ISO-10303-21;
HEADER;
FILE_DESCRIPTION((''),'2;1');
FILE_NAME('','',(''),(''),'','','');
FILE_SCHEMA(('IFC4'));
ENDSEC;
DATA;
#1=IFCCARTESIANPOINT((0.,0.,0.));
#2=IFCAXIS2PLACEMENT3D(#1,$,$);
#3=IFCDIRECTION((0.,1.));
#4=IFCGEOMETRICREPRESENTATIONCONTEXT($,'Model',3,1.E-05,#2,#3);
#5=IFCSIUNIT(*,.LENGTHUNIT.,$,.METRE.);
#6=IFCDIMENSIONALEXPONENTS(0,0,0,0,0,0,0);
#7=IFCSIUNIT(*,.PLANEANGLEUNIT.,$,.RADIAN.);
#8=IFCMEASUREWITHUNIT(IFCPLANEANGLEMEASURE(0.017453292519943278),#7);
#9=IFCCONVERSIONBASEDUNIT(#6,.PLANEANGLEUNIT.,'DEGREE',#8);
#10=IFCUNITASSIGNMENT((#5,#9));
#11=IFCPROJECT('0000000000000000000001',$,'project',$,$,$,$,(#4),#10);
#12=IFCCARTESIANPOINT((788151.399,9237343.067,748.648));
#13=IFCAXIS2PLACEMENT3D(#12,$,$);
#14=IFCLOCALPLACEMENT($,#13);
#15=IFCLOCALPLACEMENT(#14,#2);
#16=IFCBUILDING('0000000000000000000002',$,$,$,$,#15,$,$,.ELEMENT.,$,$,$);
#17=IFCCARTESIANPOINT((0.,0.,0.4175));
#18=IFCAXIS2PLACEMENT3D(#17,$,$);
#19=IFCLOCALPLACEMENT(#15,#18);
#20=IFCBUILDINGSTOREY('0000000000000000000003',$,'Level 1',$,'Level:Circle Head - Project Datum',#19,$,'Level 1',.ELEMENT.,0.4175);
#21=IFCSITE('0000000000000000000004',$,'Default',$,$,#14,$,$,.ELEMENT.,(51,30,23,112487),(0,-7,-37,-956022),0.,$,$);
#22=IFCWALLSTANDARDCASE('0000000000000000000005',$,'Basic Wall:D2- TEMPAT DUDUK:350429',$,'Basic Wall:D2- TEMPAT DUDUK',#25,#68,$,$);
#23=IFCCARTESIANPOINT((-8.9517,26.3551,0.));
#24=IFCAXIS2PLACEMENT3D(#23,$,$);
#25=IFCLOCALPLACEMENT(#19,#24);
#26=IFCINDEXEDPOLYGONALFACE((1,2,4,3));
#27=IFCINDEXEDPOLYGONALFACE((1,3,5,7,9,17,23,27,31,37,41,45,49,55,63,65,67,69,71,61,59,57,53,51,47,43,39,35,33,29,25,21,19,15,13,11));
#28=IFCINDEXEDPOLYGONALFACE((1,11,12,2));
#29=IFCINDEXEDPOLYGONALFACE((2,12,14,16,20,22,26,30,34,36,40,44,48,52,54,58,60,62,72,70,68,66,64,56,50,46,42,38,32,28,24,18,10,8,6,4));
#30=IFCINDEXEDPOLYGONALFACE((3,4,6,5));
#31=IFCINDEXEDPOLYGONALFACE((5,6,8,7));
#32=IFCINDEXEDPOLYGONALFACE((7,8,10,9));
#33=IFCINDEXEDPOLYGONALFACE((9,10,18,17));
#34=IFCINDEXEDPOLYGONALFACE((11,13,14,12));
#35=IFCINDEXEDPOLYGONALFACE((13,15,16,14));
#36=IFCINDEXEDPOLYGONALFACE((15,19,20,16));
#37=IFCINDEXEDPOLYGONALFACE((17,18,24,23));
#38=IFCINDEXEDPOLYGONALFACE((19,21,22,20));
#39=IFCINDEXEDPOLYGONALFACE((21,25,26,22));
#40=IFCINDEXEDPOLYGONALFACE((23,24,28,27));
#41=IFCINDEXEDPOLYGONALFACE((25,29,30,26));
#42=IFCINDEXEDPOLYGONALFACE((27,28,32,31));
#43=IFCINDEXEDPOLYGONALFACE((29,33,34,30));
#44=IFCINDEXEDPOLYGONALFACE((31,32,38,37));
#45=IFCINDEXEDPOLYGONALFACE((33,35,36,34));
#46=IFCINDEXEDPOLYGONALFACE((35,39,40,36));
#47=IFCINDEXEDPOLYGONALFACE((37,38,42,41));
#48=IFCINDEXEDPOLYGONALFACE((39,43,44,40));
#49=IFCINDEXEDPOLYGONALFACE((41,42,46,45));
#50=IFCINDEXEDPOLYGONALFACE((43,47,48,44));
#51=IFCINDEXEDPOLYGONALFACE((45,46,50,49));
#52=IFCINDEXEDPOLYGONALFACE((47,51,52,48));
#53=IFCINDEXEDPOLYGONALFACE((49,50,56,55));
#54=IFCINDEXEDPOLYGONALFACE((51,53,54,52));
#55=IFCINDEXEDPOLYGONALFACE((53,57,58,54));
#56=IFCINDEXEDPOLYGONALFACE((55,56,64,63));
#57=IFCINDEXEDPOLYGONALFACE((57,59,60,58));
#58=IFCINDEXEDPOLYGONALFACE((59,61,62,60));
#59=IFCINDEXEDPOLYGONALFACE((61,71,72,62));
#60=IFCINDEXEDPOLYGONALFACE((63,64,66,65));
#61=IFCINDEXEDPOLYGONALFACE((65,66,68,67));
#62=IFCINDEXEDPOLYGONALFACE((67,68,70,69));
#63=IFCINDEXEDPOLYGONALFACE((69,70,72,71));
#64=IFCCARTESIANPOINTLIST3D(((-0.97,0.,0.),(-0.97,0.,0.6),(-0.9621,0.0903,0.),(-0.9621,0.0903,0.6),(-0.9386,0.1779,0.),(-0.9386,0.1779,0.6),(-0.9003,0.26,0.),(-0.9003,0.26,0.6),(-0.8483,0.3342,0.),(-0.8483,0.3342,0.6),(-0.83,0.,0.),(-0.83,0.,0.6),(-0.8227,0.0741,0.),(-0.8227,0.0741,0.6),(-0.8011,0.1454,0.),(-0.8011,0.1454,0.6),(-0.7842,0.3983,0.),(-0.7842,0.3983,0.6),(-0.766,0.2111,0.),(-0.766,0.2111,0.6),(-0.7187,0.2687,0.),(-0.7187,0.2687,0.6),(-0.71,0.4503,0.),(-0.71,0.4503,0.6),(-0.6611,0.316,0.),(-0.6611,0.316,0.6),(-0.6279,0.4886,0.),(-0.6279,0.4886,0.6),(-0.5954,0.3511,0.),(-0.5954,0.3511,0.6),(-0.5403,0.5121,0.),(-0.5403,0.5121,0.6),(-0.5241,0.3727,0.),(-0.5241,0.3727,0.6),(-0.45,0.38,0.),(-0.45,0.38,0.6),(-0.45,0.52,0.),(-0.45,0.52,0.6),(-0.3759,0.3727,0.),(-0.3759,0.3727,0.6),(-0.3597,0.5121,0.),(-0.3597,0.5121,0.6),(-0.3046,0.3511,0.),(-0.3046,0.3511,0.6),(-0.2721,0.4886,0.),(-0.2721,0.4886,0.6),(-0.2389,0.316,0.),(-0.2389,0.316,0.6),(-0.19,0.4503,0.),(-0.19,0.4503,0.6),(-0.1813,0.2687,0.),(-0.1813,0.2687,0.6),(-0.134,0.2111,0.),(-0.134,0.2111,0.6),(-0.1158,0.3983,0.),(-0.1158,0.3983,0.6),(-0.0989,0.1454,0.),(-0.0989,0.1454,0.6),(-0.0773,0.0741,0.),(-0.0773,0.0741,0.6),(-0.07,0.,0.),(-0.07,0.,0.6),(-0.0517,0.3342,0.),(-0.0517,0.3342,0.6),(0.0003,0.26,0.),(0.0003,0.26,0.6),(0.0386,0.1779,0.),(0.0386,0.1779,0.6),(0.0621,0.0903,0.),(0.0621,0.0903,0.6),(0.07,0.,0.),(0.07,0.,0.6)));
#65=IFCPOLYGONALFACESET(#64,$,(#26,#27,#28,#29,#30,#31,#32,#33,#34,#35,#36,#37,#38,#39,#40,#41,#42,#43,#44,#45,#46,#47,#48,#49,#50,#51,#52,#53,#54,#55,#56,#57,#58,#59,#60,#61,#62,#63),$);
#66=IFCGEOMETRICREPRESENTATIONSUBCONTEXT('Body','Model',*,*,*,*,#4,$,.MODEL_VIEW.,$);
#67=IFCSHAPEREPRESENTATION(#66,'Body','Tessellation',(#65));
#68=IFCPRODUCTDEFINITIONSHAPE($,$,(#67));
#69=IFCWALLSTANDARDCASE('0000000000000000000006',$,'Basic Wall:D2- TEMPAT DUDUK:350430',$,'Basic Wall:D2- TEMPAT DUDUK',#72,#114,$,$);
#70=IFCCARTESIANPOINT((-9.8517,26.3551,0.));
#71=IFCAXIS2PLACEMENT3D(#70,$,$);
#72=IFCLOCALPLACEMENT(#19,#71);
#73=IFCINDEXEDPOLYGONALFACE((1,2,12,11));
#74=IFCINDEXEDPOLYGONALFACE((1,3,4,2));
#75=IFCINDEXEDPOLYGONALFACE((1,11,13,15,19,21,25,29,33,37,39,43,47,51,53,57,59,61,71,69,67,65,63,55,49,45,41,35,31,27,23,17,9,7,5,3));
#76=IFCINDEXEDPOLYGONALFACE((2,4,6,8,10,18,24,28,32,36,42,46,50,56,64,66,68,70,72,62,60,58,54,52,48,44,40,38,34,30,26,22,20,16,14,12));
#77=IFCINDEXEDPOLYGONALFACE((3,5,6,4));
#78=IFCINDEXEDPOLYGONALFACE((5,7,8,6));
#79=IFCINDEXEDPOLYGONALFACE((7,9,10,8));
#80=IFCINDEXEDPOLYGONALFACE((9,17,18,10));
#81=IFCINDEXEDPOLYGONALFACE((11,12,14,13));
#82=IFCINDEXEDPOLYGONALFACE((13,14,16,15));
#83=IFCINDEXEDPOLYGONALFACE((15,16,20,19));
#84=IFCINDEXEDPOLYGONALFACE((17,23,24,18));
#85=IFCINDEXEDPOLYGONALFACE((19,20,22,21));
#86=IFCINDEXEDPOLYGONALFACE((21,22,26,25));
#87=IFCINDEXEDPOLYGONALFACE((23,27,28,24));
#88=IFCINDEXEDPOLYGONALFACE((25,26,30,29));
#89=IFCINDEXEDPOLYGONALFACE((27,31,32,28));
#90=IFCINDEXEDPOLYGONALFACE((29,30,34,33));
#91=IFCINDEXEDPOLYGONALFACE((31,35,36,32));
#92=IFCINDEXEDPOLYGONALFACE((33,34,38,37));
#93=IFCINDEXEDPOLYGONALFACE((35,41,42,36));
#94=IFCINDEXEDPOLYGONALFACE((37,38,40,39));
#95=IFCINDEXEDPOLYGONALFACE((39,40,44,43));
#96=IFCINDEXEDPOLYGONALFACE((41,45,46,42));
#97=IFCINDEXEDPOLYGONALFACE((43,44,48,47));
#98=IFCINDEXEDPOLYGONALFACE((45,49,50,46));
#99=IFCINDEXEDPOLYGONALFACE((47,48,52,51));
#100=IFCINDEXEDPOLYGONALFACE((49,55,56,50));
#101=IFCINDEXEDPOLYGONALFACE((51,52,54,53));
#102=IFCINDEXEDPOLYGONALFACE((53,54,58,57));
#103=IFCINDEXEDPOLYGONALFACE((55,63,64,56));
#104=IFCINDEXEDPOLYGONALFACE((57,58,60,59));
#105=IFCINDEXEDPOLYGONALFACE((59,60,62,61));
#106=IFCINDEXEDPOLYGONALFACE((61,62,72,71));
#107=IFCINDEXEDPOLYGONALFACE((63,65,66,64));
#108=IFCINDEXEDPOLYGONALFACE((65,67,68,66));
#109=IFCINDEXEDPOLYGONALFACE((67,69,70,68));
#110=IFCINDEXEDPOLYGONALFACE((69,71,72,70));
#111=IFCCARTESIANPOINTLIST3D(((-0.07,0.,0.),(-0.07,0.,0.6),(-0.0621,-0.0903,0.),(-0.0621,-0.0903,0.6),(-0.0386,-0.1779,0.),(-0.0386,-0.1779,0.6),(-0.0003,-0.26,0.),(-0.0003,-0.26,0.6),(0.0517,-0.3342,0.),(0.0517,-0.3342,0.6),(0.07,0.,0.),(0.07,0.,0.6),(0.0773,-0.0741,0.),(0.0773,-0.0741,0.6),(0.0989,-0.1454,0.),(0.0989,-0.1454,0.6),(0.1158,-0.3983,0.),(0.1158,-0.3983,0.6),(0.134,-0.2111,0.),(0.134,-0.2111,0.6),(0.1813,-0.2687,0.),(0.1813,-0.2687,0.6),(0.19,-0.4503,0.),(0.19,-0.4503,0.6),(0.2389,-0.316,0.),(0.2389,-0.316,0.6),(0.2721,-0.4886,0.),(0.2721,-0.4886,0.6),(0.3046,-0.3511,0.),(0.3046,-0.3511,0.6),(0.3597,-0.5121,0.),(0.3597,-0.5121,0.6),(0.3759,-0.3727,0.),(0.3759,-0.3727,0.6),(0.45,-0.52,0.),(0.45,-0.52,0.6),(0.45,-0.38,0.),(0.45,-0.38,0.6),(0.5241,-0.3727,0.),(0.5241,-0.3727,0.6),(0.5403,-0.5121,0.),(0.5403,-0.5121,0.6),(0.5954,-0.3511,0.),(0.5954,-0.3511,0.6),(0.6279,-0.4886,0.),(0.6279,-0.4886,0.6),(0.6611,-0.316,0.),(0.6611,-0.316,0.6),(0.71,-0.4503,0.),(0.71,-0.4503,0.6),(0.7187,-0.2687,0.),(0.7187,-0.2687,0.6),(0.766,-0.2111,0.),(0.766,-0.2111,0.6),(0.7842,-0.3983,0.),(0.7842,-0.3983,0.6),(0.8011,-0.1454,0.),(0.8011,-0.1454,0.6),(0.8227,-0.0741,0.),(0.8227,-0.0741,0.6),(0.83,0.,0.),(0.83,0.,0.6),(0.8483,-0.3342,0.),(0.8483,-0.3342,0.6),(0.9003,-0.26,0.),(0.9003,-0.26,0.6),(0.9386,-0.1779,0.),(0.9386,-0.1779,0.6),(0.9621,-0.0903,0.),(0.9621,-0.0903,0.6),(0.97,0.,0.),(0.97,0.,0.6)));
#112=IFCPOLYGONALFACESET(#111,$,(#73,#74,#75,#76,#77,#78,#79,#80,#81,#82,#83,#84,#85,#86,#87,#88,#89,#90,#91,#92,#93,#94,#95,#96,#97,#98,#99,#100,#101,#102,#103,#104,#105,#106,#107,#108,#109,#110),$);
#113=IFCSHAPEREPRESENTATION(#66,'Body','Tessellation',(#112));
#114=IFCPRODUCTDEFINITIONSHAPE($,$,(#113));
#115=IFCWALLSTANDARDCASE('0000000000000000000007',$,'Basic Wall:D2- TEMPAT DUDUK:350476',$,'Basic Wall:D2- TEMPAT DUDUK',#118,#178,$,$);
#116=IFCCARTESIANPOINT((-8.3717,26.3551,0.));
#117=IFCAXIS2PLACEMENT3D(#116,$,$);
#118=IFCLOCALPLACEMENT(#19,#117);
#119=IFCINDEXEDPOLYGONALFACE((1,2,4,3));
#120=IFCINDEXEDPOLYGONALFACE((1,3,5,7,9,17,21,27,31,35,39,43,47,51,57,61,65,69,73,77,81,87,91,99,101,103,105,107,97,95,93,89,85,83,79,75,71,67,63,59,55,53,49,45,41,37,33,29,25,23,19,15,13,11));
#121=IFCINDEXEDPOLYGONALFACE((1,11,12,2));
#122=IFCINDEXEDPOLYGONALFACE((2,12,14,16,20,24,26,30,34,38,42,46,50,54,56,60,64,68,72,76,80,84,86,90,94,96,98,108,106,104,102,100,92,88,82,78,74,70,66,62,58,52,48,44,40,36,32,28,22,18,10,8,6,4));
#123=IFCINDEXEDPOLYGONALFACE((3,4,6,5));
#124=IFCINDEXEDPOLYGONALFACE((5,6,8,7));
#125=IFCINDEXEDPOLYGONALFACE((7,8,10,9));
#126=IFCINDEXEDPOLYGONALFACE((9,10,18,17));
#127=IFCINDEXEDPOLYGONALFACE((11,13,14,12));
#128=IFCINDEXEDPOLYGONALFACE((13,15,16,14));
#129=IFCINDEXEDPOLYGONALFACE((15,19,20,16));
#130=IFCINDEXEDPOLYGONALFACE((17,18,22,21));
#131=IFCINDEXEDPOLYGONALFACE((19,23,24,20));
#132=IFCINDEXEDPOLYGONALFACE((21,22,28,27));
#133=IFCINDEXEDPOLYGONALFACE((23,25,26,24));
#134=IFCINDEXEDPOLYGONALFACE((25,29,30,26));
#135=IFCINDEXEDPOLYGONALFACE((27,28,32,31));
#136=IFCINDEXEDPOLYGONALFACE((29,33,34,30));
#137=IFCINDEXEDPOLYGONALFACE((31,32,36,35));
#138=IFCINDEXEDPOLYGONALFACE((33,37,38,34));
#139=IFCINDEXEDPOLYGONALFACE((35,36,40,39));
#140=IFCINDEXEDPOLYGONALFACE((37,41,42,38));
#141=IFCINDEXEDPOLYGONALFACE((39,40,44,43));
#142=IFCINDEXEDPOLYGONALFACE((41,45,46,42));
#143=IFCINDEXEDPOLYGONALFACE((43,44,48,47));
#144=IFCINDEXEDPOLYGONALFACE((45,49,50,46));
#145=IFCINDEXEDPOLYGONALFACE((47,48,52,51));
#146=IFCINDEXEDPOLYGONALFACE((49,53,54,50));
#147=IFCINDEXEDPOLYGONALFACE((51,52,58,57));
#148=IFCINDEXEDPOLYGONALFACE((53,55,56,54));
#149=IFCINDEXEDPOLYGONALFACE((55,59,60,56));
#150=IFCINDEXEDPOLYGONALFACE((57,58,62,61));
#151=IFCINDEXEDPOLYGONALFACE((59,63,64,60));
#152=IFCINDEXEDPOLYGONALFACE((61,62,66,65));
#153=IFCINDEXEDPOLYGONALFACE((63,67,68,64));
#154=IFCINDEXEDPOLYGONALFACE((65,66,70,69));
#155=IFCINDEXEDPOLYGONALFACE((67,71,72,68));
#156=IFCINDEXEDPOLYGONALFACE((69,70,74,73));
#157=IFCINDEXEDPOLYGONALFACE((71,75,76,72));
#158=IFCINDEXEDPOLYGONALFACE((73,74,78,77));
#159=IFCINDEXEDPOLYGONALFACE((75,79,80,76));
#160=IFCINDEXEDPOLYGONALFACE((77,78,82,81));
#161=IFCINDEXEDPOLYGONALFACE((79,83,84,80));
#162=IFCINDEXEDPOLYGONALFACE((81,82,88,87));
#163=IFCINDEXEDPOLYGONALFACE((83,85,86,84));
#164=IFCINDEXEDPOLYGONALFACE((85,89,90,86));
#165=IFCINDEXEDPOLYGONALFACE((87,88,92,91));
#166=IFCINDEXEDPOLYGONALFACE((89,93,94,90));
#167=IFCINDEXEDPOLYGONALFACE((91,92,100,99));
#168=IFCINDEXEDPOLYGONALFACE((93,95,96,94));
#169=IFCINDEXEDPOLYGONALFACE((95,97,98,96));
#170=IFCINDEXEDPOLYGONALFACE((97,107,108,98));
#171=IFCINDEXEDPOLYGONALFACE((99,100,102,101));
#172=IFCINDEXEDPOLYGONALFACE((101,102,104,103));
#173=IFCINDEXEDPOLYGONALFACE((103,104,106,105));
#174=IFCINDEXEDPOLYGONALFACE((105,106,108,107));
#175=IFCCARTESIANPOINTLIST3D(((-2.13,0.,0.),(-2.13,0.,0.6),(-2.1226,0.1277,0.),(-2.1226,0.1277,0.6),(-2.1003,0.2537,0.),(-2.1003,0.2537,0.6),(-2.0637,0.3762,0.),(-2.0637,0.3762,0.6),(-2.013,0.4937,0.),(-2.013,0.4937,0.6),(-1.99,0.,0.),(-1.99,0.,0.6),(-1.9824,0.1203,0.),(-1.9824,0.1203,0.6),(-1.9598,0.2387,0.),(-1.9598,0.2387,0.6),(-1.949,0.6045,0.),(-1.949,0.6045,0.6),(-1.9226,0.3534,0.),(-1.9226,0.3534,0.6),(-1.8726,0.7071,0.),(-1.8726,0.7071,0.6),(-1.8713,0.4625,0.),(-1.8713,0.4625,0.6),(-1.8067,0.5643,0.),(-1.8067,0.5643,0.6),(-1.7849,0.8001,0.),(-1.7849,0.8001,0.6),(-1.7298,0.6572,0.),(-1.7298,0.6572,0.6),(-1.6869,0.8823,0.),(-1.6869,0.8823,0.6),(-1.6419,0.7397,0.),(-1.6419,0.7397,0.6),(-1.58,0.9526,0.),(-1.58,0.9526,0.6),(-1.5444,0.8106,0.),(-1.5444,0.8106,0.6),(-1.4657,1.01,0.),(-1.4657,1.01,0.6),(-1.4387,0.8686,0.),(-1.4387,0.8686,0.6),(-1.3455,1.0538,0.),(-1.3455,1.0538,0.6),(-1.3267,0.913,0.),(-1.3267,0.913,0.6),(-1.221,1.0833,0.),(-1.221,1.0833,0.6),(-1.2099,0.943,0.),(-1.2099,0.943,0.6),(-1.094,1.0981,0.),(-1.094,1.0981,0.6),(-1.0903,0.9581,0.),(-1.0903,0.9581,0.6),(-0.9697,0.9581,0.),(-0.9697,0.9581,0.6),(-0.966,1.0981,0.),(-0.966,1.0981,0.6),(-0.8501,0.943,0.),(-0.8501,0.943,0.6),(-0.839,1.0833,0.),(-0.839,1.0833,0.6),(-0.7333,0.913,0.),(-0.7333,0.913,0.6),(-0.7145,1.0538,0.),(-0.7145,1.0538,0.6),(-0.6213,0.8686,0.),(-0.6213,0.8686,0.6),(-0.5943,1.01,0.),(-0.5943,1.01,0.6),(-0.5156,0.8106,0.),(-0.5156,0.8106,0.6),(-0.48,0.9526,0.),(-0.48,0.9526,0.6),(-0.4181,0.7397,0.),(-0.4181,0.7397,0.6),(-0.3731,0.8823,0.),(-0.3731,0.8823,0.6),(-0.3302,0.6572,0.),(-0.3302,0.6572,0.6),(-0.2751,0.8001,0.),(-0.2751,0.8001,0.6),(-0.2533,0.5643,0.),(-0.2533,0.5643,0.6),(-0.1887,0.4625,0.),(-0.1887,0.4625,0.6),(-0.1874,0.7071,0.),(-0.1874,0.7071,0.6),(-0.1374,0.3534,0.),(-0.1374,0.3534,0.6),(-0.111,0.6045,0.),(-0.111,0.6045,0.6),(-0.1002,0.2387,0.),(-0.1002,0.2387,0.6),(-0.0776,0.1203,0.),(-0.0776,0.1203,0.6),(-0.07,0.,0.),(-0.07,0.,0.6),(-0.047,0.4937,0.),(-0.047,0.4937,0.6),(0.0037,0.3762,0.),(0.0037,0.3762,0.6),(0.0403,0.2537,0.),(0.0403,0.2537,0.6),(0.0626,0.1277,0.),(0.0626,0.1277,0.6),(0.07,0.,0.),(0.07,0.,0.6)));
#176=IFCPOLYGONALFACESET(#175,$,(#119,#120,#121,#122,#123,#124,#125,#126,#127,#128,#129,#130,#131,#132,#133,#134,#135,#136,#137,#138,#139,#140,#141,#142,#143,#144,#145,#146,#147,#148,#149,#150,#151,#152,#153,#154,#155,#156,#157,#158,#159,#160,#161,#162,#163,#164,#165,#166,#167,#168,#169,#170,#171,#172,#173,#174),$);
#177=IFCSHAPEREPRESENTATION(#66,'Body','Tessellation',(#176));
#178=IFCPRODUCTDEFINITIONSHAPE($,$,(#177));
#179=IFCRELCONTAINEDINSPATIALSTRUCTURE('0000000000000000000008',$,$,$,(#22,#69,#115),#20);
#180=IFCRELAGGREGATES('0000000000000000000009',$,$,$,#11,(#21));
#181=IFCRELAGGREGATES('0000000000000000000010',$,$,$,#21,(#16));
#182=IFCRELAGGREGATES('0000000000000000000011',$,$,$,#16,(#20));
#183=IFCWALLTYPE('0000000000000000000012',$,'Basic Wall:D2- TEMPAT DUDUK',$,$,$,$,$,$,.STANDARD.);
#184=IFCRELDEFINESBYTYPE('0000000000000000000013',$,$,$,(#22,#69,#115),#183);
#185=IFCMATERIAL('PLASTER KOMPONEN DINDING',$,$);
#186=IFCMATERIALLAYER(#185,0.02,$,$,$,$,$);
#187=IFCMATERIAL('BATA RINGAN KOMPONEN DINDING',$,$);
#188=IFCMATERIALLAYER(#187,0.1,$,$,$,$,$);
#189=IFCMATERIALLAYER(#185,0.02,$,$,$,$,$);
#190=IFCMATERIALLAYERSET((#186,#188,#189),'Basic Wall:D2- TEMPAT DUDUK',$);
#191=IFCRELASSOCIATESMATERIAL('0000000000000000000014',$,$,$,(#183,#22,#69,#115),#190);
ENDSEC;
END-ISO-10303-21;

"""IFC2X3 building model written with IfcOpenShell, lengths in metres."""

from ifc_helpers import new_model, entity, si_unit, converted_unit, direction, frame, frame_2d, origin, place, context, subcontext, project, spatial, polyline, circle_curve, parameter, trimmed, segment, composite_curve, outline, extrude, material, layer, layer_set, layer_usage, type_object, element, save


model = new_model("IFC2X3")

# Units and contexts
model_context = context("Model", 3, precision=1e-05, world=origin(), true_north=direction((0.0, 1.0)))
body_context = subcontext(model_context, "Body", "Model", "MODEL_VIEW")
ifc_project = project(units=[si_unit("LENGTHUNIT", "METRE"), converted_unit("PLANEANGLEUNIT", "DEGREE", entity("IfcPlaneAngleMeasure", 0.017453292519943278), si_unit("PLANEANGLEUNIT", "RADIAN"), dimensions=[0, 0, 0, 0, 0, 0, 0])], contexts=[model_context])

# Site, building, storey
site_placement = place(None, frame((788151.399, 9237343.067, 748.648)))
site = spatial("IfcSite", under=ifc_project, at=site_placement, Name="Default", CompositionType="ELEMENT", RefLatitude=(51, 30, 23, 112487), RefLongitude=(0, -7, -37, -956022), RefElevation=0.0)
building_placement = place(site_placement, origin())
building = spatial("IfcBuilding", under=site, at=building_placement, CompositionType="ELEMENT")
storey_placement = place(building_placement, frame((0.0, 0.0, 0.4175)))
storey = spatial("IfcBuildingStorey", under=building, at=storey_placement, Name="Level 1", ObjectType="Level:Circle Head - Project Datum", LongName="Level 1", CompositionType="ELEMENT", Elevation=0.4175)

# Walls
ifc_material_1 = material(Name="PLASTER KOMPONEN DINDING")
ifc_material_2 = material(Name="BATA RINGAN KOMPONEN DINDING")
ifc_layer_1 = layer(ifc_material_1, 0.02)
ifc_layer_2 = layer(ifc_material_2, 0.1)
ifc_layer_3 = layer(ifc_material_1, 0.02)
ifc_layer_set_1 = layer_set([ifc_layer_1, ifc_layer_2, ifc_layer_3], Name="Basic Wall:D2- TEMPAT DUDUK")
ifc_layer_usage_1 = layer_usage(ifc_layer_set_1, "AXIS2", "NEGATIVE", 0.07)
wall_type_1 = type_object("IfcWallType", Name="Basic Wall:D2- TEMPAT DUDUK", PredefinedType="STANDARD", material=ifc_layer_set_1)
wall_1_placement = place(storey_placement, frame((-8.9517, 26.3551, 0.0)))
element("IfcWallStandardCase", 1, at=wall_1_placement, inside=storey, type_object=wall_type_1, material=ifc_layer_usage_1, Name="Basic Wall:D2- TEMPAT DUDUK:350429", ObjectType="Basic Wall:D2- TEMPAT DUDUK", context=body_context, shape_type="SweptSolid", body=[
    extrude(outline(composite_curve([segment(trimmed(circle_curve(frame_2d((-0.45, 0.0), x_axis=(1.0, 0.0)), 0.38), [parameter(0.0)], [parameter(180.0)], True, "PARAMETER"), False, "CONTINUOUS"), segment(polyline([(-0.07, 0.0), (0.07, 0.0)]), True, "CONTINUOUS"), segment(trimmed(circle_curve(frame_2d((-0.45, 0.0), x_axis=(1.0, 0.0)), 0.52), [parameter(0.0)], [parameter(180.0)], True, "PARAMETER"), True, "CONTINUOUS"), segment(polyline([(-0.97, 0.0), (-0.83, 0.0)]), True, "CONTINUOUS")], self_intersect=False)), origin(), (0.0, 0.0, 1.0), 0.6),
])
ifc_layer_usage_2 = layer_usage(ifc_layer_set_1, "AXIS2", "NEGATIVE", 0.07)
wall_2_placement = place(storey_placement, frame((-9.8517, 26.3551, 0.0)))
element("IfcWallStandardCase", 2, at=wall_2_placement, inside=storey, type_object=wall_type_1, material=ifc_layer_usage_2, Name="Basic Wall:D2- TEMPAT DUDUK:350430", ObjectType="Basic Wall:D2- TEMPAT DUDUK", context=body_context, shape_type="SweptSolid", body=[
    extrude(outline(composite_curve([segment(trimmed(circle_curve(frame_2d((0.45, 0.0), x_axis=(1.0, 0.0)), 0.38), [parameter(180.0)], [parameter(0.0)], True, "PARAMETER"), False, "CONTINUOUS"), segment(polyline([(0.07, 0.0), (-0.07, 0.0)]), True, "CONTINUOUS"), segment(trimmed(circle_curve(frame_2d((0.45, 0.0), x_axis=(1.0, 0.0)), 0.52), [parameter(180.0)], [parameter(0.0)], True, "PARAMETER"), True, "CONTINUOUS"), segment(polyline([(0.97, 0.0), (0.83, 0.0)]), True, "CONTINUOUS")], self_intersect=False)), origin(), (0.0, 0.0, 1.0), 0.6),
])
ifc_layer_usage_3 = layer_usage(ifc_layer_set_1, "AXIS2", "NEGATIVE", 0.07)
wall_3_placement = place(storey_placement, frame((-8.3717, 26.3551, 0.0)))
element("IfcWallStandardCase", 3, at=wall_3_placement, inside=storey, type_object=wall_type_1, material=ifc_layer_usage_3, Name="Basic Wall:D2- TEMPAT DUDUK:350476", ObjectType="Basic Wall:D2- TEMPAT DUDUK", context=body_context, shape_type="SweptSolid", body=[
    extrude(outline(composite_curve([segment(trimmed(circle_curve(frame_2d((-1.03, 0.0), x_axis=(1.0, 0.0)), 0.96), [parameter(0.0)], [parameter(180.0)], True, "PARAMETER"), False, "CONTINUOUS"), segment(polyline([(-0.07, 0.0), (0.07, 0.0)]), True, "CONTINUOUS"), segment(trimmed(circle_curve(frame_2d((-1.03, 0.0), x_axis=(1.0, 0.0)), 1.1), [parameter(0.0)], [parameter(180.0)], True, "PARAMETER"), True, "CONTINUOUS"), segment(polyline([(-2.13, 0.0), (-1.99, 0.0)]), True, "CONTINUOUS")], self_intersect=False)), origin(), (0.0, 0.0, 1.0), 0.6),
])

save(model, "model.ifc")
